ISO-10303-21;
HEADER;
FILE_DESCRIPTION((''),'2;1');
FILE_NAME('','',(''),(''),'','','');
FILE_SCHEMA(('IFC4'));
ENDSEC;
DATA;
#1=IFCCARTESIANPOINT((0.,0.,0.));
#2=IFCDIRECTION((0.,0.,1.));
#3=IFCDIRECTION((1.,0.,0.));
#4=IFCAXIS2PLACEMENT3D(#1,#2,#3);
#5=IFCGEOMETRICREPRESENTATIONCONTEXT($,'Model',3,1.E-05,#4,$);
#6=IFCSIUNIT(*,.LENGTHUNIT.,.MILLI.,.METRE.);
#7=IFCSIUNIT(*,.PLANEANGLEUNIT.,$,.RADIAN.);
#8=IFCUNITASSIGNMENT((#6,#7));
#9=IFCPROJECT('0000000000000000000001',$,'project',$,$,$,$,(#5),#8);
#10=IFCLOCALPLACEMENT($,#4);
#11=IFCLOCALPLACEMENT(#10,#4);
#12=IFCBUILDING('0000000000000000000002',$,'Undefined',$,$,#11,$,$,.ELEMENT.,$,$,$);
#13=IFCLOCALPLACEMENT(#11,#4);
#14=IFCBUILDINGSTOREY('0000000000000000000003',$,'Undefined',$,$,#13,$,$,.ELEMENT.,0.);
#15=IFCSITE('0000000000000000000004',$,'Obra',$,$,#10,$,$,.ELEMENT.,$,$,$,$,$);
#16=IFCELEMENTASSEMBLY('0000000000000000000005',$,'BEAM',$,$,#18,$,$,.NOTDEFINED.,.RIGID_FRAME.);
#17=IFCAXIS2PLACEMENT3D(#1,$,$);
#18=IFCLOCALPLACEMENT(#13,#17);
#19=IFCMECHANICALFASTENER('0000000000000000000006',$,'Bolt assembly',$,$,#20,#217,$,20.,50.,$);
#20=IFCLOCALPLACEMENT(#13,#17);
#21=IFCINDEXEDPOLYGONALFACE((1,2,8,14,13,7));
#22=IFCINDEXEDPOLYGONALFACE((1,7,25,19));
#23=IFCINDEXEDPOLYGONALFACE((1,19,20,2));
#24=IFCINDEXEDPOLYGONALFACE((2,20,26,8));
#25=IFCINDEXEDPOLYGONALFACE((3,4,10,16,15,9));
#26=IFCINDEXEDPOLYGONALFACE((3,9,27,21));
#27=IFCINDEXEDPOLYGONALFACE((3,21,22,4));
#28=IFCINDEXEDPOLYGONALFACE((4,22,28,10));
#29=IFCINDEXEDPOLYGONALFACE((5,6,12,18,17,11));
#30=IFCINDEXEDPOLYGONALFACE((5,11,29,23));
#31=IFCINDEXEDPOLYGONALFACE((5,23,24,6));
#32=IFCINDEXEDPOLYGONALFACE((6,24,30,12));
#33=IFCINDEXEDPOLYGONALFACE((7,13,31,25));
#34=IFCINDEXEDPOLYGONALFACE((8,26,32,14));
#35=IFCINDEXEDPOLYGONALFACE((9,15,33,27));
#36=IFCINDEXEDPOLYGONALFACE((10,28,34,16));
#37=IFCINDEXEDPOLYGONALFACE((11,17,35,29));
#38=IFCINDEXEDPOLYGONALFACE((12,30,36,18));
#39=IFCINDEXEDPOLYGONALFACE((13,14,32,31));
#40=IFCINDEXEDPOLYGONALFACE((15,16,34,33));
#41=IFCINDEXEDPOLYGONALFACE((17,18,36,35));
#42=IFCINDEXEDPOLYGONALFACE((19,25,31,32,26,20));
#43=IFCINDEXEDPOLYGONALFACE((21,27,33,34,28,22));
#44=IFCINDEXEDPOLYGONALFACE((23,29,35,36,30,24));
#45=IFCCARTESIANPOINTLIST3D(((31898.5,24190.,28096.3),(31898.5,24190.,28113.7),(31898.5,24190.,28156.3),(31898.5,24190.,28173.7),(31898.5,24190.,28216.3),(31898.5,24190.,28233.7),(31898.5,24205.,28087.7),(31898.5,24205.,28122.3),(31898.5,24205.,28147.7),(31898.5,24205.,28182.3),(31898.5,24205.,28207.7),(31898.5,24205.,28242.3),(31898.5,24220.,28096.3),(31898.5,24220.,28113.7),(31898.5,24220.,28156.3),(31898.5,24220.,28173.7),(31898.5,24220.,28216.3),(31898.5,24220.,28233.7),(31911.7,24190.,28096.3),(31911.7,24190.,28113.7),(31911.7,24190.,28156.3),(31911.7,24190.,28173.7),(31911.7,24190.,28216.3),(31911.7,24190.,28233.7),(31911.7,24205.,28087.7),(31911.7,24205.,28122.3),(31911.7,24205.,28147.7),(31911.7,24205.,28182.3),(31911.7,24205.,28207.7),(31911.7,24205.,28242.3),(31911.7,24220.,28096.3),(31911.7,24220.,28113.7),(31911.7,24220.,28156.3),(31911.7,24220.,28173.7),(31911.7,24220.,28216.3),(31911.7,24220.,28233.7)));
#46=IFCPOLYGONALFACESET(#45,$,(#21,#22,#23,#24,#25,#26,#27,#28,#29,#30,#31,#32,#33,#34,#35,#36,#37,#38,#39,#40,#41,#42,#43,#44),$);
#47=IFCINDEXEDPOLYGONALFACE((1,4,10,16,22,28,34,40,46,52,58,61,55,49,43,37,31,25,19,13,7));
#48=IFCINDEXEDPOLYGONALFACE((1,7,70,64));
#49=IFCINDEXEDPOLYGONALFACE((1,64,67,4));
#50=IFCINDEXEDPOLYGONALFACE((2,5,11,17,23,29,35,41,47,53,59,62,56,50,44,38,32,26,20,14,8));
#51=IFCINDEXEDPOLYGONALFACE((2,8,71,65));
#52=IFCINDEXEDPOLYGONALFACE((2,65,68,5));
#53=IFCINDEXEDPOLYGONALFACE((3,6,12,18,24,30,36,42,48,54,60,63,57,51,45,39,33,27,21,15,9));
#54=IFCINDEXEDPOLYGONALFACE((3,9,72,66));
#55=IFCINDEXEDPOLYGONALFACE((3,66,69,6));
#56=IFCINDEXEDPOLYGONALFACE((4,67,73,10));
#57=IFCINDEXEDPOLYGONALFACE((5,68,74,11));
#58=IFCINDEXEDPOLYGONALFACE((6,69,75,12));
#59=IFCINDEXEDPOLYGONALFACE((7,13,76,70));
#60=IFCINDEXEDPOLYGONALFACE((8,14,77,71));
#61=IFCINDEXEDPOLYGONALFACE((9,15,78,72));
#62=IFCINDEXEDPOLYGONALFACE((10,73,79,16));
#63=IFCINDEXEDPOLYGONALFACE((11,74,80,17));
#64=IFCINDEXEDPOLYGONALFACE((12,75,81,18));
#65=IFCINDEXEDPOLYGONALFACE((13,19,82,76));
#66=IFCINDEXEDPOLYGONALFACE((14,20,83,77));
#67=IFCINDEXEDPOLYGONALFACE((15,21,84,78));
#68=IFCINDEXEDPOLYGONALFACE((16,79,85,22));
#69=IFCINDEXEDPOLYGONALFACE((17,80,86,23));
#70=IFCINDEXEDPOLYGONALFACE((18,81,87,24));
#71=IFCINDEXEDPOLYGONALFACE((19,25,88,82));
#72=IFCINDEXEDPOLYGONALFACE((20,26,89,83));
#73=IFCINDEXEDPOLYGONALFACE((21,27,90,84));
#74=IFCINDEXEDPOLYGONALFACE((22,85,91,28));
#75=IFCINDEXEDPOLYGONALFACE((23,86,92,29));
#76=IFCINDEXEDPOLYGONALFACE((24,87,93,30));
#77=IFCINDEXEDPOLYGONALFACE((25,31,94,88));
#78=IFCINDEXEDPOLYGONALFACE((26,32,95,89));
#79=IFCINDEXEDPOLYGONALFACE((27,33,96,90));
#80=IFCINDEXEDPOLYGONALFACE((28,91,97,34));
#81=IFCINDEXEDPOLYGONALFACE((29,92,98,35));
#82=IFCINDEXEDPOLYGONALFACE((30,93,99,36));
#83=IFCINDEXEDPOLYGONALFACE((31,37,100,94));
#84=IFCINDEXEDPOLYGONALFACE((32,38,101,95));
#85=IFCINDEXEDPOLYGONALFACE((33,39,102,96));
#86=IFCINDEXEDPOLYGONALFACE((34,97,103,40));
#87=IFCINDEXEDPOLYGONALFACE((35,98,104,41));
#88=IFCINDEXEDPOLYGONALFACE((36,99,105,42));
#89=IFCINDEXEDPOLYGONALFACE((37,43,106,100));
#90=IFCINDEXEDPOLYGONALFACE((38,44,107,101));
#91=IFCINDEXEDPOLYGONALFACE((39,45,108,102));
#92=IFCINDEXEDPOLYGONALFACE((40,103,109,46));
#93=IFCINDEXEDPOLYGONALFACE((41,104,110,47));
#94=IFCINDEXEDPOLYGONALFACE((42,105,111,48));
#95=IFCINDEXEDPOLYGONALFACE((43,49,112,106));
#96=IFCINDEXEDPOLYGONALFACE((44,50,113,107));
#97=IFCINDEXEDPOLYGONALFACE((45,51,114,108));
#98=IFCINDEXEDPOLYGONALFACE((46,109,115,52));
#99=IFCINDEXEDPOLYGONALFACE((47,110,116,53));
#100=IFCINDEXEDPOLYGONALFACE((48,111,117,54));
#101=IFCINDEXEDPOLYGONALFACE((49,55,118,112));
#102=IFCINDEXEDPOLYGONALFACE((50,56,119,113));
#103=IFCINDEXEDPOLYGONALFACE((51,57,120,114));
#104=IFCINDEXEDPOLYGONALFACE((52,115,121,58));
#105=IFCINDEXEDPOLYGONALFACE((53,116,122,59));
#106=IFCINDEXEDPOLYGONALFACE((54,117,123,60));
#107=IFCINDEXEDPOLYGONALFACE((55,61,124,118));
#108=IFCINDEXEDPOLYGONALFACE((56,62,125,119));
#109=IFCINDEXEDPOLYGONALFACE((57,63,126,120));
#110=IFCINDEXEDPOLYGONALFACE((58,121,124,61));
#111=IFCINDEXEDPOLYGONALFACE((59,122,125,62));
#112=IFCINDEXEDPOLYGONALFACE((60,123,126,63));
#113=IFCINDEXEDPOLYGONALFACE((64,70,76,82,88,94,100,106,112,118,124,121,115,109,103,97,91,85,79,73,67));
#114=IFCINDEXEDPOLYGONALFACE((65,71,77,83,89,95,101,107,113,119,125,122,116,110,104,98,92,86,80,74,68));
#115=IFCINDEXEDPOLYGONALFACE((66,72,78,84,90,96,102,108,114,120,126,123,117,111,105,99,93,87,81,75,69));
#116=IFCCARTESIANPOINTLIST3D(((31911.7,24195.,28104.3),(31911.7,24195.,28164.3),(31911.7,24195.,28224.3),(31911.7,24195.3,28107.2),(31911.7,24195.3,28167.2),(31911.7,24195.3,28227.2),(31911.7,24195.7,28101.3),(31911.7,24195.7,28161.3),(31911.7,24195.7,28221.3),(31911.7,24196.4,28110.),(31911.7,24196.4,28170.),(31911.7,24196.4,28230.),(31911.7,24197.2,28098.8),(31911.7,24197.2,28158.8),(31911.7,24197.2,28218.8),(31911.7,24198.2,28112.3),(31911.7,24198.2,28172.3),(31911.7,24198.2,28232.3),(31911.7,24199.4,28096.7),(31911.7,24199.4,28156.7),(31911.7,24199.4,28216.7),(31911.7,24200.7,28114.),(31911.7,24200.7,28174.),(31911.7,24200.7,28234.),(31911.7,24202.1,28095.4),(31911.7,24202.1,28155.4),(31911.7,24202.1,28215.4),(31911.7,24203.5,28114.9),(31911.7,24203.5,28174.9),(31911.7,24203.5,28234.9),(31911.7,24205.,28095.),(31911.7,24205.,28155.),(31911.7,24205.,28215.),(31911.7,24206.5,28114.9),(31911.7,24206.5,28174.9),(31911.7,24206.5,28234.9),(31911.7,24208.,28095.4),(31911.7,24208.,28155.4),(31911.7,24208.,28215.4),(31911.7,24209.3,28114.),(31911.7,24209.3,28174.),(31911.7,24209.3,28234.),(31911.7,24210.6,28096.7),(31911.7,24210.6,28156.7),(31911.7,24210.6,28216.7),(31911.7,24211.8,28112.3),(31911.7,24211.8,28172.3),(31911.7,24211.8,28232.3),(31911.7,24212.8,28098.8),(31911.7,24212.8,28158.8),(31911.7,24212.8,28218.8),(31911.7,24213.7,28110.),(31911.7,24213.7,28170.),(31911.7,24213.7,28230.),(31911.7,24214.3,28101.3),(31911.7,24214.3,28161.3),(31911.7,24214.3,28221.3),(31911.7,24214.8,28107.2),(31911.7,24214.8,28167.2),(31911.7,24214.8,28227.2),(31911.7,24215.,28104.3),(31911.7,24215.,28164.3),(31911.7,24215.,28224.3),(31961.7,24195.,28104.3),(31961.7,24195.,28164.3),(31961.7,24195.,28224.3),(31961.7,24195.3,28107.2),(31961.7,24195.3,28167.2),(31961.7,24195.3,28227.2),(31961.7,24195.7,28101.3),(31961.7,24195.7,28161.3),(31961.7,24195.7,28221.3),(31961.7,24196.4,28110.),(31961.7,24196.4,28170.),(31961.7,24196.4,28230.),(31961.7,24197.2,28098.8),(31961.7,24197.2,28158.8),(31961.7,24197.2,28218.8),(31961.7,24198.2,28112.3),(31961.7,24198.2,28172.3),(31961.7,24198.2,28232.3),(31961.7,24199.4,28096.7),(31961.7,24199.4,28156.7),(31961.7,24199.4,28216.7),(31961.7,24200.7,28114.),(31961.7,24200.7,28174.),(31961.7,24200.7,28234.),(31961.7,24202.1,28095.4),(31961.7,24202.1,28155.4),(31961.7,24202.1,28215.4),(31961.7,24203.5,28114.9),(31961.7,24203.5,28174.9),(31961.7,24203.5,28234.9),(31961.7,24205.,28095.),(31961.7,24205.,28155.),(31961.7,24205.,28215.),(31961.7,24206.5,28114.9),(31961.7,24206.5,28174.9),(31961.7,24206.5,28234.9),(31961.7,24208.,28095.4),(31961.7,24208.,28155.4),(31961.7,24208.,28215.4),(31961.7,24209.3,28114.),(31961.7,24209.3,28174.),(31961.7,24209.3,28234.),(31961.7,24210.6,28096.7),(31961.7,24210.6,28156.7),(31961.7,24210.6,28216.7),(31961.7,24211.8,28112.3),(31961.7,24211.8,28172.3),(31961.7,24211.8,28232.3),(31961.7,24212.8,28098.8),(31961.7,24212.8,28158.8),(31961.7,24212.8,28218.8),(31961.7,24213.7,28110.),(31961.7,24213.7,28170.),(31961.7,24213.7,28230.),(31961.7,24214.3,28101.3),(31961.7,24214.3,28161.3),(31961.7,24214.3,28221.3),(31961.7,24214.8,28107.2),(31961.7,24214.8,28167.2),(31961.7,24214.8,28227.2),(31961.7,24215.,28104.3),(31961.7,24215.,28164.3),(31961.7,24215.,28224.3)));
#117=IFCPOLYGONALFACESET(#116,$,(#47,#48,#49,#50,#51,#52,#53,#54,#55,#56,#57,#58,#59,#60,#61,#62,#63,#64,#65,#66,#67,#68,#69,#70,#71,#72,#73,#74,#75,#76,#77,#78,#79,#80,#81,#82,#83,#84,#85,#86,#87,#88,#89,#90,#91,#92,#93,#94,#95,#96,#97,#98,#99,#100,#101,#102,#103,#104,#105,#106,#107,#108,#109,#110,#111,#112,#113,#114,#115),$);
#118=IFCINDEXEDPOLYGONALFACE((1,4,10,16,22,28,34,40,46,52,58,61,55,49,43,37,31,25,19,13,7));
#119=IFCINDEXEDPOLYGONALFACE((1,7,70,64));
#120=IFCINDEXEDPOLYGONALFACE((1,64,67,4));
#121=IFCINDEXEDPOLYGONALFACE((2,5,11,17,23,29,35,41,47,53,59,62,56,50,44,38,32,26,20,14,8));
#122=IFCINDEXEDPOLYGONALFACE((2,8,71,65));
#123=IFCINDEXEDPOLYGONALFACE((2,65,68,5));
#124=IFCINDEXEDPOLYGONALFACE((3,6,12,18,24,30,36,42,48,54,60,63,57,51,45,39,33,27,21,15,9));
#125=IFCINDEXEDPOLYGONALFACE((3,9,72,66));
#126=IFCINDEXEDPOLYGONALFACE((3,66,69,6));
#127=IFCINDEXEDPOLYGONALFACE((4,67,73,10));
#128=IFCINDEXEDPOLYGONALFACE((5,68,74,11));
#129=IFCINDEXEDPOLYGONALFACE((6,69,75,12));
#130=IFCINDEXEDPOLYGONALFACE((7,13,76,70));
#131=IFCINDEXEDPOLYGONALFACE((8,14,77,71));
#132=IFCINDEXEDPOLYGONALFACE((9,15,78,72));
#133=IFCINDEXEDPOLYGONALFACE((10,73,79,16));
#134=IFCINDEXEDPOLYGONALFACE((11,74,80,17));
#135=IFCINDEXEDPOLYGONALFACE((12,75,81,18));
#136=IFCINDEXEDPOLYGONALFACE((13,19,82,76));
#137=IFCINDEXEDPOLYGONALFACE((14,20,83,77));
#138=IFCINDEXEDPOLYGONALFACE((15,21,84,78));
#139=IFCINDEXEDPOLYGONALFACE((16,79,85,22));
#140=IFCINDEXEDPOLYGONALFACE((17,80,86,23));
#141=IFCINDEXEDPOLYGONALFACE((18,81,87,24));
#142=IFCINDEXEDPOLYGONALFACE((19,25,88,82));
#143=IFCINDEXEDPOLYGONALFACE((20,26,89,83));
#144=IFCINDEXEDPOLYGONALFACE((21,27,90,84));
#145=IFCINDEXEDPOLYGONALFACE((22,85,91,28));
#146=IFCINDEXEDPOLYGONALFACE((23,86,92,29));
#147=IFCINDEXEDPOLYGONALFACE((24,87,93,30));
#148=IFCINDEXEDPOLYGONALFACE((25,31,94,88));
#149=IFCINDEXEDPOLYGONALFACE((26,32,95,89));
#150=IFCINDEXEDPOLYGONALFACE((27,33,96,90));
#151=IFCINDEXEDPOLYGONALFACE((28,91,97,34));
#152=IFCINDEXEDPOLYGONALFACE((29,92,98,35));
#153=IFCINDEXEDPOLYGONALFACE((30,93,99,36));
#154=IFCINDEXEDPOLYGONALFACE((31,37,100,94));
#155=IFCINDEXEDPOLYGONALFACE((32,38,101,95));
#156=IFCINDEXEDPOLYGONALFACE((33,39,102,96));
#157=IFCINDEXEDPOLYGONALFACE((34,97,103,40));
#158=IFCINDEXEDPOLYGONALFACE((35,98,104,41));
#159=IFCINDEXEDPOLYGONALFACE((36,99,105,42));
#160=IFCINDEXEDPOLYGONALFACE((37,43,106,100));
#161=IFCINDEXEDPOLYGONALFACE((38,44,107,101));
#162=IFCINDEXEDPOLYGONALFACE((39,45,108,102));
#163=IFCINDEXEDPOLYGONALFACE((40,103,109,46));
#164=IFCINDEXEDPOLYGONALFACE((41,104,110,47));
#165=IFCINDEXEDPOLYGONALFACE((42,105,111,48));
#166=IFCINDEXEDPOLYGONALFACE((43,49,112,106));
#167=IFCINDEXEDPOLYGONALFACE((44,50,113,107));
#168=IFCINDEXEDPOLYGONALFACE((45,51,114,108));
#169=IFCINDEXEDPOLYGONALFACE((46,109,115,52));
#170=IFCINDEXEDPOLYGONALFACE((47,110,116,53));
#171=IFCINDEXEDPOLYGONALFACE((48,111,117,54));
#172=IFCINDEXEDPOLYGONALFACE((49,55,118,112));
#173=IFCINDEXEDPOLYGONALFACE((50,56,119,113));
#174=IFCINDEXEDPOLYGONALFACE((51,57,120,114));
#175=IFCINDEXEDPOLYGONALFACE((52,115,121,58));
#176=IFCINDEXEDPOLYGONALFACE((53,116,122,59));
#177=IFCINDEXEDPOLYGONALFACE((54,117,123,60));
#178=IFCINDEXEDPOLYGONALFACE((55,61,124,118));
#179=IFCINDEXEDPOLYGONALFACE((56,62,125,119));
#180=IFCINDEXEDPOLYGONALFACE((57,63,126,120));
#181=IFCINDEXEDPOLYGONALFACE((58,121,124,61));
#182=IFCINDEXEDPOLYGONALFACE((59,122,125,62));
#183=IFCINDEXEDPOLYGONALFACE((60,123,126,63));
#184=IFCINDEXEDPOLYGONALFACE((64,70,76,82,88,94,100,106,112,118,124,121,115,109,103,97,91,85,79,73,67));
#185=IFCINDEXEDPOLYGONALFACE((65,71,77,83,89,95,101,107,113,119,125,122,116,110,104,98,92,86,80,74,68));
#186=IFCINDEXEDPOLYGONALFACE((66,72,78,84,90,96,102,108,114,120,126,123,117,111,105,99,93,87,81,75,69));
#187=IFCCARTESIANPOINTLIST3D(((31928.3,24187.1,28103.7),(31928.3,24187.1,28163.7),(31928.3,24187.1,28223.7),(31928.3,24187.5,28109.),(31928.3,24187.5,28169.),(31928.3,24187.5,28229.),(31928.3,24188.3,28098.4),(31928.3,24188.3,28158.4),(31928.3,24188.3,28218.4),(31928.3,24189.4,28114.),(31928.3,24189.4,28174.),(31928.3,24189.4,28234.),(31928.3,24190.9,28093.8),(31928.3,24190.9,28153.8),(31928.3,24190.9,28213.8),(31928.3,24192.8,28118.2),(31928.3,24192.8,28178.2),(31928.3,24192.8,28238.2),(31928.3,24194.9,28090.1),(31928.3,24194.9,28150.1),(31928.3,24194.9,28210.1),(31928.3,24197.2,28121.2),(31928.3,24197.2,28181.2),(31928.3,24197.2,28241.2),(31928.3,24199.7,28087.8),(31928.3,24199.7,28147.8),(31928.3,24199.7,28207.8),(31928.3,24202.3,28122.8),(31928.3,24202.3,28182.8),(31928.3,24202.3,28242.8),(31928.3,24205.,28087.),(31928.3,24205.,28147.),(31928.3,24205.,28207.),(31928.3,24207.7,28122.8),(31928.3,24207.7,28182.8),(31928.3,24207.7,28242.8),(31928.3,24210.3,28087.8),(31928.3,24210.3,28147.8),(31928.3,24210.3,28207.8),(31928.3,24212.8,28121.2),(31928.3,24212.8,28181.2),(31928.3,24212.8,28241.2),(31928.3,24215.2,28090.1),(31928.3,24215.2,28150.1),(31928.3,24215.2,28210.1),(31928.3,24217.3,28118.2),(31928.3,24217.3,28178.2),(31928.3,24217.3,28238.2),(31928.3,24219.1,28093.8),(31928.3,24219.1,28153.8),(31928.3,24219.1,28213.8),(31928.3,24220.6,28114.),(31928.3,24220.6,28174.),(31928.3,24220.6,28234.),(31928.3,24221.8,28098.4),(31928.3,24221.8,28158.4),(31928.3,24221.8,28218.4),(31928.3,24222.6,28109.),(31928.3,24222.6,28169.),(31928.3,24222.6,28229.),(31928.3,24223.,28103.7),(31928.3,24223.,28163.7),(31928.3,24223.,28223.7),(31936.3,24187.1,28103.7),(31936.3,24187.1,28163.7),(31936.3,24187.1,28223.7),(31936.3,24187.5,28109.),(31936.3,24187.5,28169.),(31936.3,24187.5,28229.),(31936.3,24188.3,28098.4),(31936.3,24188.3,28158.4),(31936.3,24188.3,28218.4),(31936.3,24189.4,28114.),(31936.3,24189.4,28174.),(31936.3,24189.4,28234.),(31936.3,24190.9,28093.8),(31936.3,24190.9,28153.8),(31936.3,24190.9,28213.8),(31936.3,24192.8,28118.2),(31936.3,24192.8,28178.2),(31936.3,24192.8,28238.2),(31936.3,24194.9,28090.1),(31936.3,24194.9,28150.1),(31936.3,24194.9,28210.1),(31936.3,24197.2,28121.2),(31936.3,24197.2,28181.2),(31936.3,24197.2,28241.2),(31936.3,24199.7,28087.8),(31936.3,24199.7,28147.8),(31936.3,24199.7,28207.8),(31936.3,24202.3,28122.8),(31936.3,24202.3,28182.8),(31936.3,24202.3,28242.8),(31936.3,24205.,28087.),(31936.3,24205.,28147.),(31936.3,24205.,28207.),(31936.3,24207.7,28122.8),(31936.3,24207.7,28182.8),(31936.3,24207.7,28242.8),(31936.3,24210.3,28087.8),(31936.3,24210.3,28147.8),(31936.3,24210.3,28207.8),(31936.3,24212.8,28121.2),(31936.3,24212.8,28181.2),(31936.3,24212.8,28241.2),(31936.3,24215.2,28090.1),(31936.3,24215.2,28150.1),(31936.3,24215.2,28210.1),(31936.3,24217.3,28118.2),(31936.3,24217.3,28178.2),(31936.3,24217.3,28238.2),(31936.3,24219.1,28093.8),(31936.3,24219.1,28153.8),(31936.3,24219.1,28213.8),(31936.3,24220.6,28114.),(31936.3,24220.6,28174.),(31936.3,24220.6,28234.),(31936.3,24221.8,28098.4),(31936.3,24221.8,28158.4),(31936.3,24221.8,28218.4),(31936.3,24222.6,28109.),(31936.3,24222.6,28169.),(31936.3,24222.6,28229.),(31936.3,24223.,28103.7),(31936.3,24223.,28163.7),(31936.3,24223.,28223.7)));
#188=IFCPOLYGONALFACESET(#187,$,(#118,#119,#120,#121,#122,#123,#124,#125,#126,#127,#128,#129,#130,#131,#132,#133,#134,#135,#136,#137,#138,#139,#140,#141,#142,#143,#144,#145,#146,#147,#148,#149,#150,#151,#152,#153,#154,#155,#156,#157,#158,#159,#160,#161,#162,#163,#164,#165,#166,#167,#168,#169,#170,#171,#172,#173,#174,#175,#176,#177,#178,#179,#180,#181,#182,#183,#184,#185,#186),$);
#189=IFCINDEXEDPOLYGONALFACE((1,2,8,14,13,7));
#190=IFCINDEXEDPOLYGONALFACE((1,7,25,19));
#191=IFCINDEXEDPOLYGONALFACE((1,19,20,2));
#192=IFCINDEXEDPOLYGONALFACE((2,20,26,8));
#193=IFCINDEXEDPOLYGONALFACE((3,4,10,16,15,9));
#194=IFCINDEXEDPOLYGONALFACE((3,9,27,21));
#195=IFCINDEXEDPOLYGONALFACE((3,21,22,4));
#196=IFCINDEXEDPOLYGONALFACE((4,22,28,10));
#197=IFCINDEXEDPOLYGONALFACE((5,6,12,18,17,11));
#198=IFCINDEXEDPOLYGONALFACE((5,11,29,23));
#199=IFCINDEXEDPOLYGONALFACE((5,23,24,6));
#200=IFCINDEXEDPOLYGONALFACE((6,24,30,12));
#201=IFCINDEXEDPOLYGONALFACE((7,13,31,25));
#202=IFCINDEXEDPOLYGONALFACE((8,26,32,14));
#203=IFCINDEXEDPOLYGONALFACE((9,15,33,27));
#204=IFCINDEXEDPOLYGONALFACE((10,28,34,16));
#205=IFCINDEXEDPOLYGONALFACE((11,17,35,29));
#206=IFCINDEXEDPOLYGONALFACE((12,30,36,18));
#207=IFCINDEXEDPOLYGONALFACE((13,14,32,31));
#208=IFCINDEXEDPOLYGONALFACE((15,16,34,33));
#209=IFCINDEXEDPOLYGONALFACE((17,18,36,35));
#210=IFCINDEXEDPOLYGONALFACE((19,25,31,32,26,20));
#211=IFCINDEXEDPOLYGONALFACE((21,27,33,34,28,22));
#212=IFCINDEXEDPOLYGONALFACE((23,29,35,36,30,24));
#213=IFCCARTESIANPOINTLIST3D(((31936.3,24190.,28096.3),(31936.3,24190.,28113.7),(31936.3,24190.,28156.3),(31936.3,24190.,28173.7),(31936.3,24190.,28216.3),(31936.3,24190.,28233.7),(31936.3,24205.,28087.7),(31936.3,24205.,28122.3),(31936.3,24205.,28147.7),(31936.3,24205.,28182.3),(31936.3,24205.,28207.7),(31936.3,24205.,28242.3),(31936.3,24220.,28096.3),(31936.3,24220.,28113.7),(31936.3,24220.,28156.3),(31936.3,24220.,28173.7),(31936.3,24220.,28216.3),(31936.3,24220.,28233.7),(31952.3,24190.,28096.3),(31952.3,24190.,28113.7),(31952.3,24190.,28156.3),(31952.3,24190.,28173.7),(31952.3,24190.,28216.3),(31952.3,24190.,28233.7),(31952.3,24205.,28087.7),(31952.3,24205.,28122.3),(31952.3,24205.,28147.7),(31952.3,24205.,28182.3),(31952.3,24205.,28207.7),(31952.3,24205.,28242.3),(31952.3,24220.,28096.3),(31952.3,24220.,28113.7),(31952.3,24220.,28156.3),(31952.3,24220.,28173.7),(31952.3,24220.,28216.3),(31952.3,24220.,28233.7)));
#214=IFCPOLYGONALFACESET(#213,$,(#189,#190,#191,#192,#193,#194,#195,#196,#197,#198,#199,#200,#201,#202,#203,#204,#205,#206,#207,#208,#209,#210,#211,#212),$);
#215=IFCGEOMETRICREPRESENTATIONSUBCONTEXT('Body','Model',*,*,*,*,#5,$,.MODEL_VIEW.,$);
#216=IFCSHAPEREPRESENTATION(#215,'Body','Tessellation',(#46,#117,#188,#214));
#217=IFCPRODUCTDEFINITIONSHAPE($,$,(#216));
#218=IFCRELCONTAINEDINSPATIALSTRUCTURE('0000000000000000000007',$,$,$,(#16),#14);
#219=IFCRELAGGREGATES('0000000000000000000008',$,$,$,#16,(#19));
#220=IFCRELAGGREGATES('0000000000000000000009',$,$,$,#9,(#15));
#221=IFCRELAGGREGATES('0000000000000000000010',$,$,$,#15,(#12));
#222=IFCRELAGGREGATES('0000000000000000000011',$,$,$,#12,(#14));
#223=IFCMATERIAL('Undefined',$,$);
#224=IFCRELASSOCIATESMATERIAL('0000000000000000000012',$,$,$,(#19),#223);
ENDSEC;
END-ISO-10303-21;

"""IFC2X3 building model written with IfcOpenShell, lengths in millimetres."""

from ifc_helpers import new_model, si_unit, frame, origin_with_axes, origin_2d_with_axis, place, context, subcontext, project, spatial, polyline, circle, outline, extrude, source, transform, mapped, material, element, aggregate, save


model = new_model("IFC2X3")

# Units and contexts
model_context = context("Model", 3, precision=1e-05, world=origin_with_axes())
body_context = subcontext(model_context, "Body", "Model", "MODEL_VIEW")
ifc_project = project(units=[si_unit("LENGTHUNIT", "METRE", prefix="MILLI"), si_unit("PLANEANGLEUNIT", "RADIAN")], contexts=[model_context])

# Site, building, storey
site_placement = place(None, origin_with_axes())
site = spatial("IfcSite", under=ifc_project, at=site_placement, Name="Obra", CompositionType="ELEMENT")
building_placement = place(site_placement, origin_with_axes())
building = spatial("IfcBuilding", under=site, at=building_placement, Name="Undefined", CompositionType="ELEMENT")
storey_placement = place(building_placement, origin_with_axes())
storey = spatial("IfcBuildingStorey", under=building, at=storey_placement, Name="Undefined", CompositionType="ELEMENT", Elevation=0.0)

# Element assembly
assembly_1_placement = place(storey_placement, origin_with_axes())
assembly_1 = element("IfcElementAssembly", 1, at=assembly_1_placement, inside=storey, Name="BEAM", AssemblyPlace="NOTDEFINED", PredefinedType="RIGID_FRAME")

# Shared definitions
ifc_material_1 = material(Name="Undefined")

# Mechanical fastener
shared_shape_1 = source(origin_with_axes(), body_context, "Body", "SweptSolid", [
    extrude(outline(polyline([(17.3, 0.0), (8.7, 15.0), (-8.7, 15.0), (-17.3, 0.0), (-8.7, -15.0), (8.7, -15.0), (17.3, 0.0)])), frame((0.0, -26.5, 0.0), z_axis=(0.0, 1.0, 0.0), x_axis=(1.0, 0.0, 0.0)), (0.0, 0.0, 1.0), 13.2),
    extrude(circle(Radius=10.0, at=origin_2d_with_axis()), frame((0.0, -13.3, 0.0), z_axis=(0.0, 1.0, 0.0), x_axis=(1.0, 0.0, 0.0)), (0.0, 0.0, 1.0), 50.0),
    extrude(circle(Radius=18.0, at=origin_2d_with_axis()), frame((0.0, 3.3, 0.0), z_axis=(0.0, 1.0, 0.0), x_axis=(1.0, 0.0, 0.0)), (0.0, 0.0, 1.0), 8.0),
    extrude(outline(polyline([(17.3, 0.0), (8.7, 15.0), (-8.7, 15.0), (-17.3, 0.0), (-8.7, -15.0), (8.7, -15.0), (17.3, 0.0)])), frame((0.0, 11.3, 0.0), z_axis=(0.0, 1.0, 0.0), x_axis=(1.0, 0.0, 0.0)), (0.0, 0.0, 1.0), 16.0),
])
mechanical_fastener_1_placement = place(assembly_1_placement, frame((31925.0, 24255.0, 28265.0), z_axis=(0.000001, -1.0, 0.0), x_axis=(0.0, 0.0, -1.0)))
mechanical_fastener_1 = element("IfcMechanicalFastener", 2, at=mechanical_fastener_1_placement, material=ifc_material_1, Name="Bolt assembly", NominalDiameter=20.0, NominalLength=50.0, context=body_context, shape_type="MappedRepresentation", body=[
    mapped(shared_shape_1, transform((40.0, 0.0, 50.0))),
    mapped(shared_shape_1, transform((100.0, 0.0, 50.0))),
    mapped(shared_shape_1, transform((160.0, 0.0, 50.0))),
])
aggregate(assembly_1, [mechanical_fastener_1])

save(model, "model.ifc")
